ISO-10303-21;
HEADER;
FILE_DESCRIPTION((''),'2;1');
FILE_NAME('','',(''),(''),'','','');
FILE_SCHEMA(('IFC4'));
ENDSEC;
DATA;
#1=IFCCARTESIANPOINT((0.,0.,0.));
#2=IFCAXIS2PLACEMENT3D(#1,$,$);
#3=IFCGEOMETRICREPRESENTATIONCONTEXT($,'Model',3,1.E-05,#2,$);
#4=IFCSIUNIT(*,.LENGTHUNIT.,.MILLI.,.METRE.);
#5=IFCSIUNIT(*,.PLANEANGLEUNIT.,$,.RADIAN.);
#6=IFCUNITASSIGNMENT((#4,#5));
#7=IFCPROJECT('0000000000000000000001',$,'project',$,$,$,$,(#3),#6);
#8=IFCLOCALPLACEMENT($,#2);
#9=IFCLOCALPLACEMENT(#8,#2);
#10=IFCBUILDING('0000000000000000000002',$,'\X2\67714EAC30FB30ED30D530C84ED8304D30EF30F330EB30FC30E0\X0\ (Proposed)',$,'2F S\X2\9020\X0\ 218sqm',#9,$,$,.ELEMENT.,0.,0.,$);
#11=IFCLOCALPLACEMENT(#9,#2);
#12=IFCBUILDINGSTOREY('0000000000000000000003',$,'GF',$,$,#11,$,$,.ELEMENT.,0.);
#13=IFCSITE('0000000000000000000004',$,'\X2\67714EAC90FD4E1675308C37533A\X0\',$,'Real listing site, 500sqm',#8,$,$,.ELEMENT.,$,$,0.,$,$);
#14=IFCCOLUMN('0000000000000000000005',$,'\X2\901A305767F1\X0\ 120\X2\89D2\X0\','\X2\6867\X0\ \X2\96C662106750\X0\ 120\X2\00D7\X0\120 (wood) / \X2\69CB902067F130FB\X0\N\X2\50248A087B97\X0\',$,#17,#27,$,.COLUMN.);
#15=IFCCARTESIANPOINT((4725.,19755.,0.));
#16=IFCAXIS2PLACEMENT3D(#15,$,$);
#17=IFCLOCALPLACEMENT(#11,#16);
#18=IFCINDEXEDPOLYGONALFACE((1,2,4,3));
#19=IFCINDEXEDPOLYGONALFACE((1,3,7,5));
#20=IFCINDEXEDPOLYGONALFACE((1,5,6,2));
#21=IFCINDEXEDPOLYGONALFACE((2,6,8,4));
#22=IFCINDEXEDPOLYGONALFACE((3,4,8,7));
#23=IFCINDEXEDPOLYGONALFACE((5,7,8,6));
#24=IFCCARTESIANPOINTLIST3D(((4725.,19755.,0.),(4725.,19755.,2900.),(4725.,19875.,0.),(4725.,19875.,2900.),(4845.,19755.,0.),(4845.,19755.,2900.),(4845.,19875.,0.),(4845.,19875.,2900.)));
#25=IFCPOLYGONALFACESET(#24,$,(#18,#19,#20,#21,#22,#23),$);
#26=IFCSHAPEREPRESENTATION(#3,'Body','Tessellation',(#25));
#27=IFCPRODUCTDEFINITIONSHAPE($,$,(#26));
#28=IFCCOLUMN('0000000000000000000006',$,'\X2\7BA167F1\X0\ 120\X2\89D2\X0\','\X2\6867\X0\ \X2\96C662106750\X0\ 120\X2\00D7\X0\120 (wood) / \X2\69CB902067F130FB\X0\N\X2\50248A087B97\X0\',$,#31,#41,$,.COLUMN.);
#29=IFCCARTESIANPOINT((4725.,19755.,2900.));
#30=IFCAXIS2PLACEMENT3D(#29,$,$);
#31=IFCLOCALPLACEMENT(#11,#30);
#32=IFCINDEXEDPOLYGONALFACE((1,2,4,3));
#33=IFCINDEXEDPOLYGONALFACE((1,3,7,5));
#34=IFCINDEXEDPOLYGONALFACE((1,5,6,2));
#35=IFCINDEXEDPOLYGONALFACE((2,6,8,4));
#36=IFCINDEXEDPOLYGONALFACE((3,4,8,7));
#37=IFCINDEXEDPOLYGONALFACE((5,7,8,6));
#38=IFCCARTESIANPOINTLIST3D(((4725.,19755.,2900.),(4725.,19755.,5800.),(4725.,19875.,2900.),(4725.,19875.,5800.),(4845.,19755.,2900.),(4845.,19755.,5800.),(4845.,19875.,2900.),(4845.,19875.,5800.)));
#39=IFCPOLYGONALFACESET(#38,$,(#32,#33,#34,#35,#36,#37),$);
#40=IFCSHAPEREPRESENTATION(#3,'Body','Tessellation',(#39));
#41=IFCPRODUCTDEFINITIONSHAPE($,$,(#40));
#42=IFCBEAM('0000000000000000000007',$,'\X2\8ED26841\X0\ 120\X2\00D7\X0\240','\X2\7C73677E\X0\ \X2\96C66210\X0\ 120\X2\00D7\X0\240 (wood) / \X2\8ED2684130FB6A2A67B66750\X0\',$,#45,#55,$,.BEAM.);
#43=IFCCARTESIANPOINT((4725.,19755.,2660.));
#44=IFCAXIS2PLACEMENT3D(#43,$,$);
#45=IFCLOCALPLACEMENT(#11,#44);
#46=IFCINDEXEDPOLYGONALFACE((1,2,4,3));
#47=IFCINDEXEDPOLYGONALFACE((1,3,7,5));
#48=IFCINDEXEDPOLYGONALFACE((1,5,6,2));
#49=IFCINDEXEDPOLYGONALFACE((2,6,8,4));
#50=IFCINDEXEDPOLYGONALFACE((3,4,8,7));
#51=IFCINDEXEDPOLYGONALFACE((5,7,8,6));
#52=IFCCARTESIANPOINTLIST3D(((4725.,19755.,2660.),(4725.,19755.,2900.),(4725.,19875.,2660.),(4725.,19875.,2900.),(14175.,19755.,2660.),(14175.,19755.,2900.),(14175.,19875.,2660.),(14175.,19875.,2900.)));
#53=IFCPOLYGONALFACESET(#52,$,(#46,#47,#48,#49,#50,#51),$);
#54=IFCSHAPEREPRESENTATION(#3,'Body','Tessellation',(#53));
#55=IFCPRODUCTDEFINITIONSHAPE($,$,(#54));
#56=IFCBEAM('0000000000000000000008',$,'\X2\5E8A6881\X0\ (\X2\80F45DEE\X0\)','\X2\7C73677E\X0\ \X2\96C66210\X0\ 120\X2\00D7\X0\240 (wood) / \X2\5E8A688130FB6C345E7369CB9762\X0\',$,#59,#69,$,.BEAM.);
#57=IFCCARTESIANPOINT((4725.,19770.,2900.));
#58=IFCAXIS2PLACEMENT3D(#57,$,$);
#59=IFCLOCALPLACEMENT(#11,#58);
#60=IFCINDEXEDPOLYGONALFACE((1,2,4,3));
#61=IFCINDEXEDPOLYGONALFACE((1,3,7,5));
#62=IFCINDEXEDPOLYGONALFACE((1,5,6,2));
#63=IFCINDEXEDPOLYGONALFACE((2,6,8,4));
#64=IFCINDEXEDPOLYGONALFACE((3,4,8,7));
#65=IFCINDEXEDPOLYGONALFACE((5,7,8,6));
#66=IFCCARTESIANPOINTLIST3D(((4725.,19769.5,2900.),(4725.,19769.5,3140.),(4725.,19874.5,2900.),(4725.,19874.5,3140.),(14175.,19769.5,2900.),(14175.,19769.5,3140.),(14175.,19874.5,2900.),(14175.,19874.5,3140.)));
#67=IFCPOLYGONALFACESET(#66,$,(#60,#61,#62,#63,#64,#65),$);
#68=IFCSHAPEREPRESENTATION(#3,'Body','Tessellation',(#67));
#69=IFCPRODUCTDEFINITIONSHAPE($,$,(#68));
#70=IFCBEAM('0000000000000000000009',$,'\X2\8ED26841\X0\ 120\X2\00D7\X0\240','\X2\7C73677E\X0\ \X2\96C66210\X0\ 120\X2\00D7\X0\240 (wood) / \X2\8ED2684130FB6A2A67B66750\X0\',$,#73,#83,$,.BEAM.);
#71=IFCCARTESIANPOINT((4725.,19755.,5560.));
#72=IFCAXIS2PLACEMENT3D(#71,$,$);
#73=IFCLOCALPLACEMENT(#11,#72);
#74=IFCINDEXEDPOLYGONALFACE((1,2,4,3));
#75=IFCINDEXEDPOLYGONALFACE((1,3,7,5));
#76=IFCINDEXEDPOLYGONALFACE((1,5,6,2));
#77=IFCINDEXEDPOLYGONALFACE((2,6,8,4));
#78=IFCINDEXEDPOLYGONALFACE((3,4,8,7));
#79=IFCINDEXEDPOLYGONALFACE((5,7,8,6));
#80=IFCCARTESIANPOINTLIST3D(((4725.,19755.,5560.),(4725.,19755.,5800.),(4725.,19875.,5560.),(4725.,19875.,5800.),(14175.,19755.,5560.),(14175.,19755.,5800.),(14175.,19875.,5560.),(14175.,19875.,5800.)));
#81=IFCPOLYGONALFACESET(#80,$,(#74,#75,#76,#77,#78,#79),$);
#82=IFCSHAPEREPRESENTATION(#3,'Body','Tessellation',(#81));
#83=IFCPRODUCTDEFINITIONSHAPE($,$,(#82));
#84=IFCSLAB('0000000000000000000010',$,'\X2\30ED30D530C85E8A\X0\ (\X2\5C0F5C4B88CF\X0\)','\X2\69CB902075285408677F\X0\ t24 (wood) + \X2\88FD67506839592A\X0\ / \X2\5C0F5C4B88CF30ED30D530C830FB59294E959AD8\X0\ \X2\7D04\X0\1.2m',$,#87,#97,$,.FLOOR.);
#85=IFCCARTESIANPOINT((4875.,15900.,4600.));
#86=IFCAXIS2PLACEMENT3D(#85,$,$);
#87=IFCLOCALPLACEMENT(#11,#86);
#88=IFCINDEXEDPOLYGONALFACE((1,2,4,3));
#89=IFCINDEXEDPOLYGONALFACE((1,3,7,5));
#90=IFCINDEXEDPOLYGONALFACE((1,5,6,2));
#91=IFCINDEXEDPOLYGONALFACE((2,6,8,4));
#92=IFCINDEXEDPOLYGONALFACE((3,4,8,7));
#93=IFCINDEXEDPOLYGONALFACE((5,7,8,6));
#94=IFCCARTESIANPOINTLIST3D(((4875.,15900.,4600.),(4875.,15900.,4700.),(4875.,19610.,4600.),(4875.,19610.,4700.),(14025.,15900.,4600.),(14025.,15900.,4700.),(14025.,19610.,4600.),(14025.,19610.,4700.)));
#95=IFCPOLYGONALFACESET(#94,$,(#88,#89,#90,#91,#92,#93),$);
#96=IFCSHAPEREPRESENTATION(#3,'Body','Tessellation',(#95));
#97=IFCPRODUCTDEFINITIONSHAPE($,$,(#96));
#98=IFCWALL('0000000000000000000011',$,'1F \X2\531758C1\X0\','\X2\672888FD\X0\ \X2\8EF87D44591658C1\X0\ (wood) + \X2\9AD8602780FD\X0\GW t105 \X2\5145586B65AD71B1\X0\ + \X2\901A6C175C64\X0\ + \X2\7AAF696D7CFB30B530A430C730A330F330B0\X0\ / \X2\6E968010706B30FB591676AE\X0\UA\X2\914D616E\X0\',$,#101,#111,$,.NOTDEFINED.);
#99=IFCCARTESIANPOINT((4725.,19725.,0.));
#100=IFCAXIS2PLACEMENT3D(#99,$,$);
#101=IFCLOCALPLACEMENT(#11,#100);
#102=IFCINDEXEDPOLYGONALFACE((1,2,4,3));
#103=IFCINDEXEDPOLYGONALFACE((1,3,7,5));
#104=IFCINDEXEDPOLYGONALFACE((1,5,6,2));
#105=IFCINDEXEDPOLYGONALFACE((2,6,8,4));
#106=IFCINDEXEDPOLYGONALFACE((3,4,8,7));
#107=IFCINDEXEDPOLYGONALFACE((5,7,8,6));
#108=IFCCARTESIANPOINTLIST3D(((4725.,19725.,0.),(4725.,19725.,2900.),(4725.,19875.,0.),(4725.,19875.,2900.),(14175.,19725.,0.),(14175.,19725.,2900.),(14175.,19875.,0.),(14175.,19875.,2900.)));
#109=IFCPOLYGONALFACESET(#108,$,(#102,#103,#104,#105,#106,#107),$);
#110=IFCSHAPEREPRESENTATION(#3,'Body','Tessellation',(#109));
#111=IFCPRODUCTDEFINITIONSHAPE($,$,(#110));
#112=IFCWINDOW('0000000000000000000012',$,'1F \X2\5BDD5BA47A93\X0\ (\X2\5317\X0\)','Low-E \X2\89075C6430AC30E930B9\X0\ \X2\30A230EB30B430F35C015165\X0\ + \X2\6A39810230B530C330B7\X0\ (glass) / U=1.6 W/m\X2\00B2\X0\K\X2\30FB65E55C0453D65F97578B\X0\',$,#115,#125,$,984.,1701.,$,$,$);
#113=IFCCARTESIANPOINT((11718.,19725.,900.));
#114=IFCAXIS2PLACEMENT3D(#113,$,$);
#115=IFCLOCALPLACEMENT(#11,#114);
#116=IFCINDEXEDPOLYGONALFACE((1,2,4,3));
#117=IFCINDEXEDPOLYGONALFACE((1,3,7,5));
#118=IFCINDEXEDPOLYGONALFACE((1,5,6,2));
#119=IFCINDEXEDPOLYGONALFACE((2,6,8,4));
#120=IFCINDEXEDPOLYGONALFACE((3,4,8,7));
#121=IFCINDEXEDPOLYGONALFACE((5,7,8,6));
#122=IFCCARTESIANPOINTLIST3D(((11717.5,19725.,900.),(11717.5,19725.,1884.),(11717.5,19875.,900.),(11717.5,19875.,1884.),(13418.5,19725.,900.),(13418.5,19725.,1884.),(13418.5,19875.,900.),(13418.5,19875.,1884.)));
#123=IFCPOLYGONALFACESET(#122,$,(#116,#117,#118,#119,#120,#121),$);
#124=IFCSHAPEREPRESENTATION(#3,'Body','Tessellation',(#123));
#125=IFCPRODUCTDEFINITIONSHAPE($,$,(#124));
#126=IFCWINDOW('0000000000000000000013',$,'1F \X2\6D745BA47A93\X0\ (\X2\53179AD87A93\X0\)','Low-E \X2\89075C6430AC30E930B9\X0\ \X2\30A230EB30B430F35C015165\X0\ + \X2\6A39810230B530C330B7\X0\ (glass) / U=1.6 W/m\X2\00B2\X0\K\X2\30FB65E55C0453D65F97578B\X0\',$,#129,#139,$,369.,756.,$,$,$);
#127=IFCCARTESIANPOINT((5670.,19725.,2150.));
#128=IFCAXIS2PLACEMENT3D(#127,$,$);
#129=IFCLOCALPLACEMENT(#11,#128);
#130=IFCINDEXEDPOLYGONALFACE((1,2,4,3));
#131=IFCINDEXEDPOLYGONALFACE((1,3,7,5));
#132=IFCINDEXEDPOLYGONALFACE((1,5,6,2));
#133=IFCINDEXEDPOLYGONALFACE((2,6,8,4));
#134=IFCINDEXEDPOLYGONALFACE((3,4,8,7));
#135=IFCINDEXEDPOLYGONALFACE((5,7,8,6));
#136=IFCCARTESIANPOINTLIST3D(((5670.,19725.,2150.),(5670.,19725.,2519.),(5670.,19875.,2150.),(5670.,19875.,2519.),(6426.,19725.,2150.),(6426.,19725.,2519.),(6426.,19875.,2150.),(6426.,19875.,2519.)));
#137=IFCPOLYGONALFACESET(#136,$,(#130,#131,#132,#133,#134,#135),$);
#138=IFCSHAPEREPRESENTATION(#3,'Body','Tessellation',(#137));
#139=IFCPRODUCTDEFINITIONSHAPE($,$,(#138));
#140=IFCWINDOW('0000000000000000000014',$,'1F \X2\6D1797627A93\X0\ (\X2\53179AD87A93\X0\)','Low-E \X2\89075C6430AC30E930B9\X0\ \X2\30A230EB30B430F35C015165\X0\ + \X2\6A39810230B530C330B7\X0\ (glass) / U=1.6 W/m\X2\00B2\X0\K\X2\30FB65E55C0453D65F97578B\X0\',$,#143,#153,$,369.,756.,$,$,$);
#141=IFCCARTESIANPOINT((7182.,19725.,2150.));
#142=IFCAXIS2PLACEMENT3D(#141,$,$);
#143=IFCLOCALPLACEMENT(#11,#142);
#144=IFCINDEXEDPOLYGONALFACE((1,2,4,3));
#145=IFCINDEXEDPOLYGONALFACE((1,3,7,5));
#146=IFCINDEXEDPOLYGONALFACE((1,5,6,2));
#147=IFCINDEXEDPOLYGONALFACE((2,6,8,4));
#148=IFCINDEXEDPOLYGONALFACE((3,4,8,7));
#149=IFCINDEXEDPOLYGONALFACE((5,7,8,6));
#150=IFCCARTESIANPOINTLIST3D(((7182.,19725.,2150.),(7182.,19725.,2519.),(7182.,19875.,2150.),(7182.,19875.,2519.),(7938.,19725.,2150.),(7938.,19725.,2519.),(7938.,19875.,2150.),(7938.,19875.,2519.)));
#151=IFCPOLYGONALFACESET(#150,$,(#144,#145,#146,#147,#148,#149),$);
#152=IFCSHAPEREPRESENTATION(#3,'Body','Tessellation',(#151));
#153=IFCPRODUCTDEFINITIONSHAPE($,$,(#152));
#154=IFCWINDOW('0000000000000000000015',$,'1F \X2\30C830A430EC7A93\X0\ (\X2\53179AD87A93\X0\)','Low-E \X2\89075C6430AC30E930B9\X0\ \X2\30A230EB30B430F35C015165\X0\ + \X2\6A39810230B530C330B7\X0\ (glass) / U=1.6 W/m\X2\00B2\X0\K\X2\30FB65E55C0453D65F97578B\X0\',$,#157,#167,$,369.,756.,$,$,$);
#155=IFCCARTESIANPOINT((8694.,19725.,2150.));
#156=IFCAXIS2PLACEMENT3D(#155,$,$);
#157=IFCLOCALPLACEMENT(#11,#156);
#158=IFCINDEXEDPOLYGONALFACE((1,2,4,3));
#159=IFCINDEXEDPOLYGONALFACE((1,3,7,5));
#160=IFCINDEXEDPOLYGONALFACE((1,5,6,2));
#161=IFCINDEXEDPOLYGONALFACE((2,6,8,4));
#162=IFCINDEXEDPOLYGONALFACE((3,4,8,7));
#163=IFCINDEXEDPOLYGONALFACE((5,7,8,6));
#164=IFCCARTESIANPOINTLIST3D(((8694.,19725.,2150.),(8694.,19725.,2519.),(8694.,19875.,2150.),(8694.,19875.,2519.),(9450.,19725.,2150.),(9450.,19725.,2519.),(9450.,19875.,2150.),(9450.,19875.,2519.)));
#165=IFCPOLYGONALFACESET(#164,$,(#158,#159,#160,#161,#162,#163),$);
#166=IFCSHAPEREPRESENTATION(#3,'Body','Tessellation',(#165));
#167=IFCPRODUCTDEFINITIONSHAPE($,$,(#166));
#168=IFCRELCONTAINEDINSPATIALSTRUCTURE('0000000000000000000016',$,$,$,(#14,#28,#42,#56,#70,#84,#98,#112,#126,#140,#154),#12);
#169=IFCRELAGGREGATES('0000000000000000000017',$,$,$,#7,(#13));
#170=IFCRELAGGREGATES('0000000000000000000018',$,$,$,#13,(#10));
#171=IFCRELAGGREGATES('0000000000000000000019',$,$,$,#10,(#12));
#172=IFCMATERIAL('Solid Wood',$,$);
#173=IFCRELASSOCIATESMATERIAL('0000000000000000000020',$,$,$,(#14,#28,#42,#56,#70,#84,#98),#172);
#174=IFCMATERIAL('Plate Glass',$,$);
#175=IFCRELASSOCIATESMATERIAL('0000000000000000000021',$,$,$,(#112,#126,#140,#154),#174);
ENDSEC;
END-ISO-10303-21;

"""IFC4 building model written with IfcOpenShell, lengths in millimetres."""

from ifc_helpers import new_model, si_unit, frame, frame_2d, origin, place, context, project, spatial, rectangle, extrude, material, element, fill, save


model = new_model("IFC4")

# Units and contexts
model_context = context("Model", 3, precision=1e-05, world=origin())
ifc_project = project(units=[si_unit("LENGTHUNIT", "METRE", prefix="MILLI"), si_unit("PLANEANGLEUNIT", "RADIAN")], contexts=[model_context])

# Site, building, storey
site_placement = place(None, origin())
site = spatial("IfcSite", under=ifc_project, at=site_placement, Name="東京都世田谷区", ObjectType="Real listing site, 500sqm", CompositionType="ELEMENT", RefElevation=0.0)
building_placement = place(site_placement, origin())
building = spatial("IfcBuilding", under=site, at=building_placement, Name="東京・ロフト付きワンルーム (Proposed)", ObjectType="2F S造 218sqm", CompositionType="ELEMENT", ElevationOfRefHeight=0.0, ElevationOfTerrain=0.0)
storey_placement = place(building_placement, origin())
storey = spatial("IfcBuildingStorey", under=building, at=storey_placement, Name="GF", CompositionType="ELEMENT", Elevation=0.0)

# Columns
ifc_material_1 = material(Name="Solid Wood")
column_1_placement = place(storey_placement, frame((4725.0, 19755.0, 0.0)))
element("IfcColumn", 1, at=column_1_placement, inside=storey, material=ifc_material_1, Name="通し柱 120角", Description="桧 集成材 120×120 (wood) / 構造柱・N値計算", PredefinedType="COLUMN", context=model_context, shape_type="SweptSolid", body=[
    extrude(rectangle(XDim=120.0, YDim=120.0, at=frame_2d((60.0, 60.0))), frame((4725.0, 19755.0, 0.0)), (0.0, 0.0, 1.0), 2900.0),
])
column_2_placement = place(storey_placement, frame((4725.0, 19755.0, 2900.0)))
element("IfcColumn", 2, at=column_2_placement, inside=storey, material=ifc_material_1, Name="管柱 120角", Description="桧 集成材 120×120 (wood) / 構造柱・N値計算", PredefinedType="COLUMN", context=model_context, shape_type="SweptSolid", body=[
    extrude(rectangle(XDim=120.0, YDim=120.0, at=frame_2d((60.0, 60.0))), frame((4725.0, 19755.0, 2900.0)), (0.0, 0.0, 1.0), 2900.0),
])

# Beams
beam_1_placement = place(storey_placement, frame((4725.0, 19755.0, 2660.0)))
element("IfcBeam", 3, at=beam_1_placement, inside=storey, material=ifc_material_1, Name="軒桁 120×240", Description="米松 集成 120×240 (wood) / 軒桁・横架材", PredefinedType="BEAM", context=model_context, shape_type="SweptSolid", body=[
    extrude(rectangle(XDim=9450.0, YDim=120.0, at=frame_2d((4725.0, 60.0))), frame((4725.0, 19755.0, 2660.0)), (0.0, 0.0, 1.0), 240.0),
])
beam_2_placement = place(storey_placement, frame((4725.0, 19770.0, 2900.0)))
element("IfcBeam", 4, at=beam_2_placement, inside=storey, material=ifc_material_1, Name="床梁 (胴差)", Description="米松 集成 120×240 (wood) / 床梁・水平構面", PredefinedType="BEAM", context=model_context, shape_type="SweptSolid", body=[
    extrude(rectangle(XDim=9450.0, YDim=105.0, at=frame_2d((4725.0, 52.0))), frame((4725.0, 19770.0, 2900.0)), (0.0, 0.0, 1.0), 240.0),
])
beam_3_placement = place(storey_placement, frame((4725.0, 19755.0, 5560.0)))
element("IfcBeam", 5, at=beam_3_placement, inside=storey, material=ifc_material_1, Name="軒桁 120×240", Description="米松 集成 120×240 (wood) / 軒桁・横架材", PredefinedType="BEAM", context=model_context, shape_type="SweptSolid", body=[
    extrude(rectangle(XDim=9450.0, YDim=120.0, at=frame_2d((4725.0, 60.0))), frame((4725.0, 19755.0, 5560.0)), (0.0, 0.0, 1.0), 240.0),
])

# Slab
slab_placement = place(storey_placement, frame((4875.0, 15900.0, 4600.0)))
element("IfcSlab", 6, at=slab_placement, inside=storey, material=ifc_material_1, Name="ロフト床 (小屋裏)", Description="構造用合板 t24 (wood) + 製材根太 / 小屋裏ロフト・天井高 約1.2m", PredefinedType="FLOOR", context=model_context, shape_type="SweptSolid", body=[
    extrude(rectangle(XDim=9150.0, YDim=3710.0, at=frame_2d((4575.0, 1855.0))), frame((4875.0, 15900.0, 4600.0)), (0.0, 0.0, 1.0), 100.0),
])

# Wall, openings, windows
wall_1_placement = place(storey_placement, frame((4725.0, 19725.0, 0.0)))
wall_1 = element("IfcWall", 7, at=wall_1_placement, inside=storey, material=ifc_material_1, Name="1F 北壁", Description="木製 軸組外壁 (wood) + 高性能GW t105 充填断熱 + 通気層 + 窯業系サイディング / 準耐火・外皮UA配慮", PredefinedType="NOTDEFINED", context=model_context, shape_type="SweptSolid", body=[
    extrude(rectangle(XDim=9450.0, YDim=150.0, at=frame_2d((4725.0, 75.0))), frame((4725.0, 19725.0, 0.0)), (0.0, 0.0, 1.0), 2900.0),
])
opening_1_placement = place(storey_placement, frame((11718.0, 19725.0, 900.0)))
opening_1 = element("IfcOpeningElement", 8, at=opening_1_placement, cuts=wall_1, PredefinedType="NOTDEFINED", context=model_context, shape_type="SweptSolid", body=[
    extrude(rectangle(XDim=1701.0, YDim=150.0, at=frame_2d((850.0, 75.0))), frame((11718.0, 19725.0, 900.0)), (0.0, 0.0, 1.0), 984.0),
])
opening_2_placement = place(storey_placement, frame((5670.0, 19725.0, 2150.0)))
opening_2 = element("IfcOpeningElement", 9, at=opening_2_placement, cuts=wall_1, PredefinedType="NOTDEFINED", context=model_context, shape_type="SweptSolid", body=[
    extrude(rectangle(XDim=756.0, YDim=150.0, at=frame_2d((378.0, 75.0))), frame((5670.0, 19725.0, 2150.0)), (0.0, 0.0, 1.0), 369.0),
])
opening_3_placement = place(storey_placement, frame((7182.0, 19725.0, 2150.0)))
opening_3 = element("IfcOpeningElement", 10, at=opening_3_placement, cuts=wall_1, PredefinedType="NOTDEFINED", context=model_context, shape_type="SweptSolid", body=[
    extrude(rectangle(XDim=756.0, YDim=150.0, at=frame_2d((378.0, 75.0))), frame((7182.0, 19725.0, 2150.0)), (0.0, 0.0, 1.0), 369.0),
])
opening_4_placement = place(storey_placement, frame((8694.0, 19725.0, 2150.0)))
opening_4 = element("IfcOpeningElement", 11, at=opening_4_placement, cuts=wall_1, PredefinedType="NOTDEFINED", context=model_context, shape_type="SweptSolid", body=[
    extrude(rectangle(XDim=756.0, YDim=150.0, at=frame_2d((378.0, 75.0))), frame((8694.0, 19725.0, 2150.0)), (0.0, 0.0, 1.0), 369.0),
])
ifc_material_2 = material(Name="Plate Glass")
window_1_placement = place(storey_placement, frame((11718.0, 19725.0, 900.0)))
window_1 = element("IfcWindow", 12, at=window_1_placement, inside=storey, material=ifc_material_2, Name="1F 寝室窓 (北)", Description="Low-E 複層ガラス アルゴン封入 + 樹脂サッシ (glass) / U=1.6 W/m²K・日射取得型", OverallHeight=984.0, OverallWidth=1701.0, context=model_context, shape_type="SweptSolid", body=[
    extrude(rectangle(XDim=1701.0, YDim=150.0, at=frame_2d((850.0, 75.0))), frame((11718.0, 19725.0, 900.0)), (0.0, 0.0, 1.0), 984.0),
])
fill(opening_1, window_1)
window_2_placement = place(storey_placement, frame((5670.0, 19725.0, 2150.0)))
window_2 = element("IfcWindow", 13, at=window_2_placement, inside=storey, material=ifc_material_2, Name="1F 浴室窓 (北高窓)", Description="Low-E 複層ガラス アルゴン封入 + 樹脂サッシ (glass) / U=1.6 W/m²K・日射取得型", OverallHeight=369.0, OverallWidth=756.0, context=model_context, shape_type="SweptSolid", body=[
    extrude(rectangle(XDim=756.0, YDim=150.0, at=frame_2d((378.0, 75.0))), frame((5670.0, 19725.0, 2150.0)), (0.0, 0.0, 1.0), 369.0),
])
fill(opening_2, window_2)
window_3_placement = place(storey_placement, frame((7182.0, 19725.0, 2150.0)))
window_3 = element("IfcWindow", 14, at=window_3_placement, inside=storey, material=ifc_material_2, Name="1F 洗面窓 (北高窓)", Description="Low-E 複層ガラス アルゴン封入 + 樹脂サッシ (glass) / U=1.6 W/m²K・日射取得型", OverallHeight=369.0, OverallWidth=756.0, context=model_context, shape_type="SweptSolid", body=[
    extrude(rectangle(XDim=756.0, YDim=150.0, at=frame_2d((378.0, 75.0))), frame((7182.0, 19725.0, 2150.0)), (0.0, 0.0, 1.0), 369.0),
])
fill(opening_3, window_3)
window_4_placement = place(storey_placement, frame((8694.0, 19725.0, 2150.0)))
window_4 = element("IfcWindow", 15, at=window_4_placement, inside=storey, material=ifc_material_2, Name="1F トイレ窓 (北高窓)", Description="Low-E 複層ガラス アルゴン封入 + 樹脂サッシ (glass) / U=1.6 W/m²K・日射取得型", OverallHeight=369.0, OverallWidth=756.0, context=model_context, shape_type="SweptSolid", body=[
    extrude(rectangle(XDim=756.0, YDim=150.0, at=frame_2d((378.0, 75.0))), frame((8694.0, 19725.0, 2150.0)), (0.0, 0.0, 1.0), 369.0),
])
fill(opening_4, window_4)

save(model, "model.ifc")
